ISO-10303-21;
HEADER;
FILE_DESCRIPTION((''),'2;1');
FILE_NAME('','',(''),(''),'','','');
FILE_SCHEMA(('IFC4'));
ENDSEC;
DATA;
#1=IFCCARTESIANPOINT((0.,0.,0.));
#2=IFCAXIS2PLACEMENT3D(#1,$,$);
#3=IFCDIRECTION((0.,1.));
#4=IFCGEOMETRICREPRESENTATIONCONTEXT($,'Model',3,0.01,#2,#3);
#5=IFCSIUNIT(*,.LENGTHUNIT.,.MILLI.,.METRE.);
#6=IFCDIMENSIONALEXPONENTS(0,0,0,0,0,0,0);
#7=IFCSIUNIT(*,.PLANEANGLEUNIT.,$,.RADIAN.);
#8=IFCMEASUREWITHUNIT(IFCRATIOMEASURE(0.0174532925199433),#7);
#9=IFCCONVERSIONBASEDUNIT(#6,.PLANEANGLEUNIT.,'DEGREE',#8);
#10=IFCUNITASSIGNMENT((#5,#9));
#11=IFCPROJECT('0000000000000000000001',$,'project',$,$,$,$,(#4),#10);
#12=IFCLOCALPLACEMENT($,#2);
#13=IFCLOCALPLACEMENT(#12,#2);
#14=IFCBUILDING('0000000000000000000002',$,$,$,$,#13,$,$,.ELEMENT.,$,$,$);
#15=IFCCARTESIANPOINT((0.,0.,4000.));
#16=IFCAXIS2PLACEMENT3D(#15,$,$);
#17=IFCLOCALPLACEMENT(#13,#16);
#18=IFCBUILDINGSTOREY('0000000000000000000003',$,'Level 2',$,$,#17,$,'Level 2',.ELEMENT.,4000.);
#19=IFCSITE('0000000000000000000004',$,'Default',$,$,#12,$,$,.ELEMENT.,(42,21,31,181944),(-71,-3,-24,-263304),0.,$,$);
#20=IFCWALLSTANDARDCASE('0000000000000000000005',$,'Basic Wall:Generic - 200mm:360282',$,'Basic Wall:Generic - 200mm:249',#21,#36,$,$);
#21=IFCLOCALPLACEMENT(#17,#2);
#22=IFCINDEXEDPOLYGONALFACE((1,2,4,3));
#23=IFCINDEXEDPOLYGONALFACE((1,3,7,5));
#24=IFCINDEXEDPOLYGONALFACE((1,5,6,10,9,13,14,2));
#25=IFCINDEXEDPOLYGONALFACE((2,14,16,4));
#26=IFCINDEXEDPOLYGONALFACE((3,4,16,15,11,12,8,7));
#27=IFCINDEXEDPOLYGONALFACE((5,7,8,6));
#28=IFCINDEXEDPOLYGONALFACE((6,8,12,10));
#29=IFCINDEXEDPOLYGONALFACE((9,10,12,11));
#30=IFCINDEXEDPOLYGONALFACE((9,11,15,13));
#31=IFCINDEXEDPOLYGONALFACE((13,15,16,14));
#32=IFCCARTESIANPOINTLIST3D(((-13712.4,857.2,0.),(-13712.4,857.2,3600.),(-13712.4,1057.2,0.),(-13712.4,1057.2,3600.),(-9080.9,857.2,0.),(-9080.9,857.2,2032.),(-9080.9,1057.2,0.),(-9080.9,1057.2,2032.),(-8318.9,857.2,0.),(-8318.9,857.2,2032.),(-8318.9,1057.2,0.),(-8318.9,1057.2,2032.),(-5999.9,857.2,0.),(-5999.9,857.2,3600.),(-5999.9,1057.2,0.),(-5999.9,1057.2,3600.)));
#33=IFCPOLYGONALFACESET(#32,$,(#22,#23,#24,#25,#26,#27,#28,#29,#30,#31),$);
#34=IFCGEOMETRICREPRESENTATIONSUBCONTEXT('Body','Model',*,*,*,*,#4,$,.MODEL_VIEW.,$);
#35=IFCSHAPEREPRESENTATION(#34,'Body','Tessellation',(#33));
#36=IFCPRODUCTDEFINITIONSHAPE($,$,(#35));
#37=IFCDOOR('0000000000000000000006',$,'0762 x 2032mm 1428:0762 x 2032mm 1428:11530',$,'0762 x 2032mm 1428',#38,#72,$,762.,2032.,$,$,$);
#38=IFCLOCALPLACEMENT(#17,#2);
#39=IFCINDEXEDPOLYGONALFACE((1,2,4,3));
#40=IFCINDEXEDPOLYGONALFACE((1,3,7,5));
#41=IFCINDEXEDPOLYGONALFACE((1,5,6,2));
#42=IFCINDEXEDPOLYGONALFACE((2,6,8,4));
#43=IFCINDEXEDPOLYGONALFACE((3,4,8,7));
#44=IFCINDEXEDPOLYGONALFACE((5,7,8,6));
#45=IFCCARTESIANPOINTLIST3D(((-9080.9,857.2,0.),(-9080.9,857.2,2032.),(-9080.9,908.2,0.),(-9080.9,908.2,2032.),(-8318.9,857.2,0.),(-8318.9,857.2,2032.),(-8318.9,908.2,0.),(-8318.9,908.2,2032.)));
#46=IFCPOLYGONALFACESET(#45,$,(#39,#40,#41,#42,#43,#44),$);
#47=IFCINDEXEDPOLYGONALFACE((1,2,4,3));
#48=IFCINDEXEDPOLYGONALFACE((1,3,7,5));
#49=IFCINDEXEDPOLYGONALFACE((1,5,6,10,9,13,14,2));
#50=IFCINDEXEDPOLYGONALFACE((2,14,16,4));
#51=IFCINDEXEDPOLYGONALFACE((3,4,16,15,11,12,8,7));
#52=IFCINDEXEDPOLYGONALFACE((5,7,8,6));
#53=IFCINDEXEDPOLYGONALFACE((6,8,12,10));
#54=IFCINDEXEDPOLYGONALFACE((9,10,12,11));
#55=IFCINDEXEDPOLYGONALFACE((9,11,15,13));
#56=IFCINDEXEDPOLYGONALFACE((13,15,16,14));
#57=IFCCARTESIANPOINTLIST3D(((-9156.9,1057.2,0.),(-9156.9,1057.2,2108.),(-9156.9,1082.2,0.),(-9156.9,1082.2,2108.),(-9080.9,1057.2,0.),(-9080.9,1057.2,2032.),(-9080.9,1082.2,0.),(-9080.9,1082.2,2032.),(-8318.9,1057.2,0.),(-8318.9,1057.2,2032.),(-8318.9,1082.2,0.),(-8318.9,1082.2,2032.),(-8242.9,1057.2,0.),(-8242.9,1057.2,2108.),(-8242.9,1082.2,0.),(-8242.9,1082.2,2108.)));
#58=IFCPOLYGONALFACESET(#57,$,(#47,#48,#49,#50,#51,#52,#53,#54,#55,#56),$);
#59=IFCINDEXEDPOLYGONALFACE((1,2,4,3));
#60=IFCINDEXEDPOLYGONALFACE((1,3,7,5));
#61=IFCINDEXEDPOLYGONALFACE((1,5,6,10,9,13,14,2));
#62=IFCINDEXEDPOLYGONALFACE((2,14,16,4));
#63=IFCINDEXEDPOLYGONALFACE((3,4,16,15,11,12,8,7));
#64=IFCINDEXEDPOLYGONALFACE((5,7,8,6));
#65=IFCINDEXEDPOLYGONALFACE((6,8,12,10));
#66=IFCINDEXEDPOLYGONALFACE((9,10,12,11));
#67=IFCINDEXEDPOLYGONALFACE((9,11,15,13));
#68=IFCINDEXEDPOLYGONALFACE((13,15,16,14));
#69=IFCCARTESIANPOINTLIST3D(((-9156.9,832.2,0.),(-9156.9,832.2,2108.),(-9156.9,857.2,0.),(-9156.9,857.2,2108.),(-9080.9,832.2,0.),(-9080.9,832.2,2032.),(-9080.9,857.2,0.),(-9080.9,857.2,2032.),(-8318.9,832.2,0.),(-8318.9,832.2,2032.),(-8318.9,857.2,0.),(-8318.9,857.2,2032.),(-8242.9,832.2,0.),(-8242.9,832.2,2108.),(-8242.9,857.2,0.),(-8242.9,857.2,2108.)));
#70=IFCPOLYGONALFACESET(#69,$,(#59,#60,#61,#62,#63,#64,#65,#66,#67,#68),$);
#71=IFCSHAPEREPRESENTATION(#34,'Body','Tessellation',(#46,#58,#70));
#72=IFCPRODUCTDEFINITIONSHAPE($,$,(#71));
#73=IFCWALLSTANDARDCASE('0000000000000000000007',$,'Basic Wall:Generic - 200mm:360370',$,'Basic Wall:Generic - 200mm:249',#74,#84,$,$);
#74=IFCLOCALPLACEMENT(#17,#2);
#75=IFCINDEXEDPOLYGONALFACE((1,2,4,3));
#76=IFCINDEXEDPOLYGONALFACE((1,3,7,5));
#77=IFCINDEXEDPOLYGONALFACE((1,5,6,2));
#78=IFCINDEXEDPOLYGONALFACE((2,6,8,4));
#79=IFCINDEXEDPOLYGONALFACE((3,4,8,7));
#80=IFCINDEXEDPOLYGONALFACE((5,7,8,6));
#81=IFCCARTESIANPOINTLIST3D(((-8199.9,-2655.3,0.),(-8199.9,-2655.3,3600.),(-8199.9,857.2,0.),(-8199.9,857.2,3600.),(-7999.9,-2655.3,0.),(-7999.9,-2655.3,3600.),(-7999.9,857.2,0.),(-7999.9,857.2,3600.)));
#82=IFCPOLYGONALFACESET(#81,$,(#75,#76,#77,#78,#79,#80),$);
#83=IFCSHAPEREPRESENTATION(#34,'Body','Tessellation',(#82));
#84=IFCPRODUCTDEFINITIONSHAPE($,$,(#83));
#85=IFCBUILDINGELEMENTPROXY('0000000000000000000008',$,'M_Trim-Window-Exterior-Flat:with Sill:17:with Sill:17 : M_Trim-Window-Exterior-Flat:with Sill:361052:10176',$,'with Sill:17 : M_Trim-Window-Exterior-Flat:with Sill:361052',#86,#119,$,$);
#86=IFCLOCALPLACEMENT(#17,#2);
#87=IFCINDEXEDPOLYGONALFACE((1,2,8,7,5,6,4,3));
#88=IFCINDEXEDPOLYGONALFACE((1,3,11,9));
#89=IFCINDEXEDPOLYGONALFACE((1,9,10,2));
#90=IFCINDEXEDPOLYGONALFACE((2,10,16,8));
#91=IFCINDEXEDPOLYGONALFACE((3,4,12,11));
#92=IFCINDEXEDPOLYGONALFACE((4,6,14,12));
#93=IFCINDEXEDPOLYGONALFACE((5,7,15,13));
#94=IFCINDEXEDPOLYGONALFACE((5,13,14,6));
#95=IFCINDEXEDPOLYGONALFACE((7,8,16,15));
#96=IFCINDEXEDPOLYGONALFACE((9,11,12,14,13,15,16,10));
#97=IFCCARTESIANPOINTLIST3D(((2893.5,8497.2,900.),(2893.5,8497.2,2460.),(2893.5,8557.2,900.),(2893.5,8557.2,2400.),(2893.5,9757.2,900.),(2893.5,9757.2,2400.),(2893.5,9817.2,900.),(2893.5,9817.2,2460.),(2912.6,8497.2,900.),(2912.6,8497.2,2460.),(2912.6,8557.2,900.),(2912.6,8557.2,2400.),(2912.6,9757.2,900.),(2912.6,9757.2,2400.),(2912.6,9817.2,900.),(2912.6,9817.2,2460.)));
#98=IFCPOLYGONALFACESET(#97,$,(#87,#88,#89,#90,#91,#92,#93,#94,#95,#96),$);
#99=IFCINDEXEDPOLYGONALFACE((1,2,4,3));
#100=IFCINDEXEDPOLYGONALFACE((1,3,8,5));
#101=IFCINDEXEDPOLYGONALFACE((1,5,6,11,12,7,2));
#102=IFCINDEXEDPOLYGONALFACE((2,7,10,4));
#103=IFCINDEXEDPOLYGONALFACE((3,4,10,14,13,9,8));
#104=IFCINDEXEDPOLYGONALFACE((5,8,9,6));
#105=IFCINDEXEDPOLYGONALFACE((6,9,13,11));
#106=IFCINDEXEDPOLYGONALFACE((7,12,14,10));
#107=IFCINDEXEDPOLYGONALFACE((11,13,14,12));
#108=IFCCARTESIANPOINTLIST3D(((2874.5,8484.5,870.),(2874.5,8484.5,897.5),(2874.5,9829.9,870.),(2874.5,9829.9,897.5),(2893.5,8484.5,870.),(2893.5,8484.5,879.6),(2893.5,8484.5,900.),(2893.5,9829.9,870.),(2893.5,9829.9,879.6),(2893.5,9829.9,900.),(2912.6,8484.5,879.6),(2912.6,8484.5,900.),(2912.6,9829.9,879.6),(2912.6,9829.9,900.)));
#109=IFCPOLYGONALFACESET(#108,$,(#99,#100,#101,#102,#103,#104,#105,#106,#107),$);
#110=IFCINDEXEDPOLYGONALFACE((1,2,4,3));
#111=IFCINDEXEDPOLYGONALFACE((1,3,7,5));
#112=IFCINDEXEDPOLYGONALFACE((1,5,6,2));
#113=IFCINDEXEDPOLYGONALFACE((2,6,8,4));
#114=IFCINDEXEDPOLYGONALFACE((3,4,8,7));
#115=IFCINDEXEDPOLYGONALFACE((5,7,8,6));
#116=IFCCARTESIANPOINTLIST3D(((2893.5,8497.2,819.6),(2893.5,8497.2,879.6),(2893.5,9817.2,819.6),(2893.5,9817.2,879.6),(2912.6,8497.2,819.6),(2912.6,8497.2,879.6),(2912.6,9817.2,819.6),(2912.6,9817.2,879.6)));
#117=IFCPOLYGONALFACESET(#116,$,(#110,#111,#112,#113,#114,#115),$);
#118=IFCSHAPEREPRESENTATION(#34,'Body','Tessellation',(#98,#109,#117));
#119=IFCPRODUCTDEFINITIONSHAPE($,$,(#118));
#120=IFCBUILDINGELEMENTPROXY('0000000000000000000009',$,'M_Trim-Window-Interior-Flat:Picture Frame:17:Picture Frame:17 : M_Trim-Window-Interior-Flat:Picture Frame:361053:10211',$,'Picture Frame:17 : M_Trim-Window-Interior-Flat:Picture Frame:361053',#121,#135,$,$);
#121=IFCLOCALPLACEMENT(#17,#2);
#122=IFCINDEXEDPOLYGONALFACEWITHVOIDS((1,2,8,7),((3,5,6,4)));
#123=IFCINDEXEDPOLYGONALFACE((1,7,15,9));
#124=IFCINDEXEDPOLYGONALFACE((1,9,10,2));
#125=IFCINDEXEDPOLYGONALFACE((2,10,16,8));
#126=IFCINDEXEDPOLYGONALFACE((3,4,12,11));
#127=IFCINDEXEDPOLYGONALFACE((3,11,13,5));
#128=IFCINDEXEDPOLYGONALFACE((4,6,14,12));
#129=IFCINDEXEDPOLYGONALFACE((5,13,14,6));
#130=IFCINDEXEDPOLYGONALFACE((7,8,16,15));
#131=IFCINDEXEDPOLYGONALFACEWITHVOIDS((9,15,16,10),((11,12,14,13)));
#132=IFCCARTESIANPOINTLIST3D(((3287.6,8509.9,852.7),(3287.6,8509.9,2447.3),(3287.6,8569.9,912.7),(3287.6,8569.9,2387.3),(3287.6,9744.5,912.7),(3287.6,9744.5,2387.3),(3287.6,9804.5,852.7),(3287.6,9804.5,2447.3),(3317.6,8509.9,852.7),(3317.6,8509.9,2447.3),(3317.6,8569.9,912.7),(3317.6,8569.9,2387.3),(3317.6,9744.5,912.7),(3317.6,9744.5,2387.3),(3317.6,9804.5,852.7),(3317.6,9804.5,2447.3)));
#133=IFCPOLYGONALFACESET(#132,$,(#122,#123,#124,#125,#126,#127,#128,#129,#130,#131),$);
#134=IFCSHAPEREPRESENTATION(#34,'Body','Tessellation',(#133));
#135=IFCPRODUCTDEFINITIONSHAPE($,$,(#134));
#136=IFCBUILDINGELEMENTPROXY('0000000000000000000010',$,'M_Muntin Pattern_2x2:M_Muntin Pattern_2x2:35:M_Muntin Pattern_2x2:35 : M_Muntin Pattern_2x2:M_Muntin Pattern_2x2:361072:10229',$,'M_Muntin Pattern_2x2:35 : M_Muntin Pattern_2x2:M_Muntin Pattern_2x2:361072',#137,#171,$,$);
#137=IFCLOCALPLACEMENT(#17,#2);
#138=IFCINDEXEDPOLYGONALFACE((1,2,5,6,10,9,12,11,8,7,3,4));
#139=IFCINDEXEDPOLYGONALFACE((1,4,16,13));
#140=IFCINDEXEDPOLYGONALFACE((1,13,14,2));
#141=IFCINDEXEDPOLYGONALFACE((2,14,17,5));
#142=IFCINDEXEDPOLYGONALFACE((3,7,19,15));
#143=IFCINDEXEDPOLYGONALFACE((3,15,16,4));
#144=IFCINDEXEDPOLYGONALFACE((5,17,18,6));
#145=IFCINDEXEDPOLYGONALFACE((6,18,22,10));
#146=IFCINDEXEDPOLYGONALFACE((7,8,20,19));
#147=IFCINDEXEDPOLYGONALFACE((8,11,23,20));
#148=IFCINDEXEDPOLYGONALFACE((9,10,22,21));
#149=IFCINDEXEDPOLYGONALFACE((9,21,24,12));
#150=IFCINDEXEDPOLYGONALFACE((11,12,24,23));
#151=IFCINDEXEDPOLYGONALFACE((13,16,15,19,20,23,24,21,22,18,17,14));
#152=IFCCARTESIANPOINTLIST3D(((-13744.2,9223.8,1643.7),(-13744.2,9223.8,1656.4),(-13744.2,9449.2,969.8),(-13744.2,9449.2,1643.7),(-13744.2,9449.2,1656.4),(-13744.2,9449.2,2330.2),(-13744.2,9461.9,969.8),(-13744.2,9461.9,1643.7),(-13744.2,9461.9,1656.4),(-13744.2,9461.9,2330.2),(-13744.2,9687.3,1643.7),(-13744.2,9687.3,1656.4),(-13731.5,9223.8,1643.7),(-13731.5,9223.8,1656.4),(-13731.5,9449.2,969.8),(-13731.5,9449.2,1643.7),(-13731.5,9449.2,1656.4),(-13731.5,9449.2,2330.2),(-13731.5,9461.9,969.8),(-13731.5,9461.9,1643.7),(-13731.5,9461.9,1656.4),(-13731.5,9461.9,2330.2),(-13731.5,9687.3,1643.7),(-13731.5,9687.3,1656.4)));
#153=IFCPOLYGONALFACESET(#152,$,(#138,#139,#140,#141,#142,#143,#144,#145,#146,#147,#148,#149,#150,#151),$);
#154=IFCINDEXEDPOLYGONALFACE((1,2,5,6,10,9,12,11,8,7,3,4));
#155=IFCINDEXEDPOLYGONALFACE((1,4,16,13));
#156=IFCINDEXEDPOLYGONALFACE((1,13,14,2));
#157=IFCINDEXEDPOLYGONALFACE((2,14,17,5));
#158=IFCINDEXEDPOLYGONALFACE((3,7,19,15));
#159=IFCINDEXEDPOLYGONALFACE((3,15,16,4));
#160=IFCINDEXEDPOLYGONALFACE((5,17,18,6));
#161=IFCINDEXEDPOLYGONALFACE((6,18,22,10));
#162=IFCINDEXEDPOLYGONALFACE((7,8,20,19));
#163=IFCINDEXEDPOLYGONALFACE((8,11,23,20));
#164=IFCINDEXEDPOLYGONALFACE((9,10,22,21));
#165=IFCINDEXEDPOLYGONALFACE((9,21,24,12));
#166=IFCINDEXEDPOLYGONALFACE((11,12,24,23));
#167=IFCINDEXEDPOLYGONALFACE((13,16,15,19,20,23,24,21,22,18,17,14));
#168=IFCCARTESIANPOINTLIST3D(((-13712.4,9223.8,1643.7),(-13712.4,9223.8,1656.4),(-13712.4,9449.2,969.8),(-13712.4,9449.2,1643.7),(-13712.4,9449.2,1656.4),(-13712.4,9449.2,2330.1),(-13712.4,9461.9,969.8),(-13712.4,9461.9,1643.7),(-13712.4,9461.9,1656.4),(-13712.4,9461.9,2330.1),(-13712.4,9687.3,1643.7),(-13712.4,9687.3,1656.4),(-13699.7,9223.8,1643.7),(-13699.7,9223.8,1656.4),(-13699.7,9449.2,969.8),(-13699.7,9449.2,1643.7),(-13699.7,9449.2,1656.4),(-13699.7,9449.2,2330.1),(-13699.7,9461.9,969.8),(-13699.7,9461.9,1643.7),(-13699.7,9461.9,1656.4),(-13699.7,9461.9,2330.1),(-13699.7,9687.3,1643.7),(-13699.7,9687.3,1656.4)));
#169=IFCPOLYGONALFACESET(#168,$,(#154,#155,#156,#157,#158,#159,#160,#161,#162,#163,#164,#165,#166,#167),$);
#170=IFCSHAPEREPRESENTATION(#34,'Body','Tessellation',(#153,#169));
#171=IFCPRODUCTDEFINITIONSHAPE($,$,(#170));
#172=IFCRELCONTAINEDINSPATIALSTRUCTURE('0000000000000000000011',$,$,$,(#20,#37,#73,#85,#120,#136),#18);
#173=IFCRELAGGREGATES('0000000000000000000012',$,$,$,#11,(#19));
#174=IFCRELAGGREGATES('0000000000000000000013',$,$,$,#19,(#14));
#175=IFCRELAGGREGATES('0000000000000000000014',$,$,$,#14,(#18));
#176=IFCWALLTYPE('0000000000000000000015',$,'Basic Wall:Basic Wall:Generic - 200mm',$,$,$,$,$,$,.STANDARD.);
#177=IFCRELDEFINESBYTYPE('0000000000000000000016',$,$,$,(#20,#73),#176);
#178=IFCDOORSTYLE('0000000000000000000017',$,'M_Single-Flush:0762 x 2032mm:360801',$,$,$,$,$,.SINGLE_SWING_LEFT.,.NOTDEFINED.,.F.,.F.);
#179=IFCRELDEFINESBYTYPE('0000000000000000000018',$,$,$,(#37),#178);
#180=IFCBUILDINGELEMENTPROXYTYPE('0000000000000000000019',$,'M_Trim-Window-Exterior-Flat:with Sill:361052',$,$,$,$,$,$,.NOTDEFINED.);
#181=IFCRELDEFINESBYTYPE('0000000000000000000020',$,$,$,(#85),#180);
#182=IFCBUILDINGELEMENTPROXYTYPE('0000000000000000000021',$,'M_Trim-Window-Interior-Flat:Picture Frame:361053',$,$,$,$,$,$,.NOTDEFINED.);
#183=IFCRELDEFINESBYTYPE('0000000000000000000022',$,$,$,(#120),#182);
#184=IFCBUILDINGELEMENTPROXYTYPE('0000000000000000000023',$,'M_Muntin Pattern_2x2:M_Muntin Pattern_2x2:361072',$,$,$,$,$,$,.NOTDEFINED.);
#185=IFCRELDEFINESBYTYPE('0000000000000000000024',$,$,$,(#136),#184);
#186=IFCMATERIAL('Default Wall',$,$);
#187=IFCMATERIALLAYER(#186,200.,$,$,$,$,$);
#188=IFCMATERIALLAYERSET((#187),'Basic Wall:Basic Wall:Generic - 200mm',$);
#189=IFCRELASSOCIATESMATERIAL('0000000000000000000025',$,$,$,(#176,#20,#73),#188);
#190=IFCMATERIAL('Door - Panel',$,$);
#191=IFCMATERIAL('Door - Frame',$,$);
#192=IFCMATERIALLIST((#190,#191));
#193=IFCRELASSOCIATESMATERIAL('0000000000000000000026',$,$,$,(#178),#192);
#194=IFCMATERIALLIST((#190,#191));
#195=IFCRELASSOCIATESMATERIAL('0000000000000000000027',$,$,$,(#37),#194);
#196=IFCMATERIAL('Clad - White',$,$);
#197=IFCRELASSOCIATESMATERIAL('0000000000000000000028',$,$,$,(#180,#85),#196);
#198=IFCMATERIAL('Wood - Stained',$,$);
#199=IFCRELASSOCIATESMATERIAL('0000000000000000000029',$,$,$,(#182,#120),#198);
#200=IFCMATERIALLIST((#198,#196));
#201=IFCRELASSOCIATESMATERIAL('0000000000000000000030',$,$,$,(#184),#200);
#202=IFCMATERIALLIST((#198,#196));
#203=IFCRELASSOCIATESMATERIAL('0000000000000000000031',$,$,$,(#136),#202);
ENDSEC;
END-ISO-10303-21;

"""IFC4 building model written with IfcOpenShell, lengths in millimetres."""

from ifc_helpers import new_model, entity, si_unit, converted_unit, direction, frame, frame_2d, origin, origin_2d_with_axis, place, context, subcontext, project, spatial, polyline, rectangle, outline, extrude, source, transform, mapped, material, material_list, layer, layer_set, layer_usage, type_object, type_shapes, element, fill, save


model = new_model("IFC4")

# Units and contexts
model_context = context("Model", 3, precision=0.01, world=origin(), true_north=direction((0.0, 1.0)))
body_context = subcontext(model_context, "Body", "Model", "MODEL_VIEW")
ifc_project = project(units=[si_unit("LENGTHUNIT", "METRE", prefix="MILLI"), converted_unit("PLANEANGLEUNIT", "DEGREE", entity("IfcRatioMeasure", 0.0174532925199433), si_unit("PLANEANGLEUNIT", "RADIAN"), dimensions=[0, 0, 0, 0, 0, 0, 0])], contexts=[model_context])

# Site, building, storey
site_placement = place(None, origin())
site = spatial("IfcSite", under=ifc_project, at=site_placement, Name="Default", CompositionType="ELEMENT", RefLatitude=(42, 21, 31, 181944), RefLongitude=(-71, -3, -24, -263304), RefElevation=0.0)
building_placement = place(site_placement, origin())
building = spatial("IfcBuilding", under=site, at=building_placement, CompositionType="ELEMENT")
storey_placement = place(building_placement, frame((0.0, 0.0, 4000.0)))
storey = spatial("IfcBuildingStorey", under=building, at=storey_placement, Name="Level 2", LongName="Level 2", CompositionType="ELEMENT", Elevation=4000.0)

# Shared definitions
ifc_material_1 = material(Name="Default Wall")
ifc_material_2 = material(Name="Door - Panel")
ifc_material_3 = material(Name="Door - Frame")

# Shared definitions
ifc_layer_1 = layer(ifc_material_1, 200.0)
ifc_layer_set_1 = layer_set([ifc_layer_1], Name="Basic Wall:Basic Wall:Generic - 200mm")
wall_type_1 = type_object("IfcWallType", Name="Basic Wall:Basic Wall:Generic - 200mm", PredefinedType="STANDARD", material=ifc_layer_set_1)
ifc_material_list_1 = material_list([ifc_material_2, ifc_material_3])
door_style_1 = type_object("IfcDoorStyle", Name="M_Single-Flush:0762 x 2032mm:360801", ConstructionType="NOTDEFINED", OperationType="SINGLE_SWING_LEFT", ParameterTakesPrecedence=False, Sizeable=False, material=ifc_material_list_1)
shared_shape_1 = source(origin(), body_context, "Body", "SweptSolid", [
    extrude(rectangle(XDim=51.0, YDim=762.0, at=origin_2d_with_axis()), frame((381.0, -27.5, 0.0), z_axis=(0.0, 0.0, 1.0), x_axis=(0.0, 1.0, 0.0)), (0.0, 0.0, 1.0), 2032.0),
    extrude(outline(polyline([(-1035.0, -457.0), (1073.0, -457.0), (1073.0, 457.0), (-1035.0, 457.0), (-1035.0, 381.0), (997.0, 381.0), (997.0, -381.0), (-1035.0, -381.0), (-1035.0, -457.0)])), frame((381.0, -227.0, 1035.0), z_axis=(0.0, 1.0, 0.0), x_axis=(0.0, 0.0, 1.0)), (0.0, 0.0, 1.0), 25.0),
    extrude(outline(polyline([(-457.0, -1073.0), (457.0, -1073.0), (457.0, 1035.0), (381.0, 1035.0), (381.0, -997.0), (-381.0, -997.0), (-381.0, 1035.0), (-457.0, 1035.0), (-457.0, -1073.0)])), frame((381.0, -2.0, 1035.0), z_axis=(0.0, 1.0, 0.0), x_axis=(1.0, 0.0, 0.0)), (0.0, 0.0, 1.0), 25.0),
])
type_shapes(door_style_1, [shared_shape_1])

# Wall, opening, door
ifc_layer_usage_1 = layer_usage(ifc_layer_set_1, "AXIS2", "NEGATIVE", 100.0)
wall_1_placement = place(storey_placement, frame((-5999.9, 957.2, 0.0), z_axis=(0.0, 0.0, 1.0), x_axis=(-1.0, 0.0, 0.0)))
wall_1 = element("IfcWallStandardCase", 1, at=wall_1_placement, inside=storey, type_object=wall_type_1, material=ifc_layer_usage_1, Name="Basic Wall:Generic - 200mm:360282", ObjectType="Basic Wall:Generic - 200mm:249", context=body_context, shape_type="SweptSolid", body=[
    extrude(rectangle(XDim=7712.5, YDim=200.0, at=frame_2d((3856.2, 0.0), x_axis=(-1.0, 0.0))), origin(), (0.0, 0.0, 1.0), 3600.0),
])
opening_1_placement = place(wall_1_placement, frame((-5999.9, 957.2, 0.0), z_axis=(0.0, 0.0, 1.0), x_axis=(-1.0, 0.0, 0.0)))
opening_1 = element("IfcOpeningElement", 2, at=opening_1_placement, cuts=wall_1, ObjectType="Opening", context=body_context, shape_type="SweptSolid", body=[
    extrude(rectangle(XDim=2032.0, YDim=762.0, at=frame_2d((0.0, 0.0), x_axis=(1.0, 0.0))), frame((-8699.9, 1059.2, 1016.0), z_axis=(0.0, -1.0, 0.0), x_axis=(0.0, 0.0, 1.0)), (0.0, 0.0, 1.0), 204.0),
])
ifc_material_list_2 = material_list([ifc_material_2, ifc_material_3])
door_1_placement = place(opening_1_placement, frame((-8318.9, 855.2, 0.0), z_axis=(0.0, 0.0, 1.0), x_axis=(-1.0, 0.0, 0.0)))
door_1 = element("IfcDoor", 3, at=door_1_placement, inside=storey, type_object=door_style_1, material=ifc_material_list_2, Name="0762 x 2032mm 1428:0762 x 2032mm 1428:11530", ObjectType="0762 x 2032mm 1428", OverallHeight=762.0, OverallWidth=2032.0, context=body_context, shape_type="MappedRepresentation", body=[
    mapped(shared_shape_1, transform((0.0, 0.0, 0.0), scale=1.0)),
])
fill(opening_1, door_1)

# Wall
ifc_layer_usage_2 = layer_usage(ifc_layer_set_1, "AXIS2", "NEGATIVE", 100.0)
wall_2_placement = place(storey_placement, frame((-8099.9, 857.2, 0.0), z_axis=(0.0, 0.0, 1.0), x_axis=(0.0, -1.0, 0.0)))
element("IfcWallStandardCase", 4, at=wall_2_placement, inside=storey, type_object=wall_type_1, material=ifc_layer_usage_2, Name="Basic Wall:Generic - 200mm:360370", ObjectType="Basic Wall:Generic - 200mm:249", context=body_context, shape_type="SweptSolid", body=[
    extrude(rectangle(XDim=3512.5, YDim=200.0, at=frame_2d((1756.2, 0.0), x_axis=(-1.0, 0.0))), origin(), (0.0, 0.0, 1.0), 3600.0),
])

# Building element proxies
ifc_material_4 = material(Name="Clad - White")
building_element_proxy_type_1 = type_object("IfcBuildingElementProxyType", Name="M_Trim-Window-Exterior-Flat:with Sill:361052", PredefinedType="NOTDEFINED", material=ifc_material_4)
shared_shape_2 = source(origin(), body_context, "Body", "SweptSolid", [
    extrude(outline(polyline([(-765.0, -660.0), (795.0, -660.0), (795.0, 660.0), (-765.0, 660.0), (-765.0, 600.0), (735.0, 600.0), (735.0, -600.0), (-765.0, -600.0), (-765.0, -660.0)])), frame((2893.5, 9157.2, 5665.0), z_axis=(1.0, 0.0, 0.0), x_axis=(0.0, 0.0, 1.0)), (0.0, 0.0, 1.0), 19.1),
    extrude(outline(polyline([(0.0, -15.2), (19.0, -15.2), (19.0, 12.3), (0.0, 14.8), (-19.0, 14.8), (-19.0, -5.7), (0.0, -5.7), (0.0, -15.2)])), frame((2893.5, 8484.5, 4885.2), z_axis=(0.0, 1.0, 0.0), x_axis=(-1.0, 0.0, 0.0)), (0.0, 0.0, 1.0), 1345.4),
    extrude(rectangle(XDim=19.1, YDim=1320.0, at=frame_2d((0.0, 0.0), x_axis=(1.0, 0.0))), frame((2903.0, 9157.2, 4819.6)), (0.0, 0.0, 1.0), 60.0),
])
type_shapes(building_element_proxy_type_1, [shared_shape_2])
proxy_1_placement = place(storey_placement, frame((0.0, 0.0, -4000.0)))
element("IfcBuildingElementProxy", 5, at=proxy_1_placement, inside=storey, type_object=building_element_proxy_type_1, material=ifc_material_4, Name="M_Trim-Window-Exterior-Flat:with Sill:17:with Sill:17 : M_Trim-Window-Exterior-Flat:with Sill:361052:10176", ObjectType="with Sill:17 : M_Trim-Window-Exterior-Flat:with Sill:361052", context=body_context, shape_type="MappedRepresentation", body=[
    mapped(shared_shape_2, transform((0.0, 0.0, 0.0), scale=1.0)),
])
ifc_material_5 = material(Name="Wood - Stained")
building_element_proxy_type_2 = type_object("IfcBuildingElementProxyType", Name="M_Trim-Window-Interior-Flat:Picture Frame:361053", PredefinedType="NOTDEFINED", material=ifc_material_5)
shared_shape_3 = source(origin(), body_context, "Body", "SweptSolid", [
    extrude(outline(polyline([(-797.3, -647.3), (797.3, -647.3), (797.3, 647.3), (-797.3, 647.3), (-797.3, -647.3)]), holes=[polyline([(737.3, 587.3), (737.3, -587.3), (-737.3, -587.3), (-737.3, 587.3), (737.3, 587.3)])]), frame((3287.6, 9157.2, 5650.0), z_axis=(1.0, 0.0, 0.0), x_axis=(0.0, 0.0, -1.0)), (0.0, 0.0, 1.0), 30.0),
])
type_shapes(building_element_proxy_type_2, [shared_shape_3])
proxy_2_placement = place(storey_placement, frame((0.0, 0.0, -4000.0)))
element("IfcBuildingElementProxy", 6, at=proxy_2_placement, inside=storey, type_object=building_element_proxy_type_2, material=ifc_material_5, Name="M_Trim-Window-Interior-Flat:Picture Frame:17:Picture Frame:17 : M_Trim-Window-Interior-Flat:Picture Frame:361053:10211", ObjectType="Picture Frame:17 : M_Trim-Window-Interior-Flat:Picture Frame:361053", context=body_context, shape_type="MappedRepresentation", body=[
    mapped(shared_shape_3, transform((0.0, 0.0, 0.0), scale=1.0)),
])
ifc_material_list_3 = material_list([ifc_material_5, ifc_material_4])
ifc_material_list_4 = material_list([ifc_material_5, ifc_material_4])
building_element_proxy_type_3 = type_object("IfcBuildingElementProxyType", Name="M_Muntin Pattern_2x2:M_Muntin Pattern_2x2:361072", PredefinedType="NOTDEFINED", material=ifc_material_list_4)
shared_shape_4 = source(origin(), body_context, "Body", "SweptSolid", [
    extrude(outline(polyline([(-6.4, -680.2), (6.3, -680.2), (6.3, -6.4), (231.7, -6.4), (231.7, 6.3), (6.3, 6.3), (6.3, 680.2), (-6.4, 680.2), (-6.4, 6.3), (-231.7, 6.3), (-231.7, -6.4), (-6.4, -6.4), (-6.4, -680.2)])), frame((-13744.2, 9455.6, 5650.0), z_axis=(1.0, 0.0, 0.0), x_axis=(0.0, -1.0, 0.0)), (0.0, 0.0, 1.0), 12.7),
    extrude(outline(polyline([(-6.4, -680.1), (6.3, -680.1), (6.3, -6.4), (231.7, -6.4), (231.7, 6.3), (6.3, 6.3), (6.3, 680.2), (-6.4, 680.2), (-6.4, 6.3), (-231.7, 6.3), (-231.7, -6.4), (-6.4, -6.4), (-6.4, -680.1)])), frame((-13712.4, 9455.6, 5650.0), z_axis=(1.0, 0.0, 0.0), x_axis=(0.0, -1.0, 0.0)), (0.0, 0.0, 1.0), 12.7),
])
type_shapes(building_element_proxy_type_3, [shared_shape_4])
proxy_3_placement = place(storey_placement, frame((0.0, 0.0, -4000.0)))
element("IfcBuildingElementProxy", 7, at=proxy_3_placement, inside=storey, type_object=building_element_proxy_type_3, material=ifc_material_list_3, Name="M_Muntin Pattern_2x2:M_Muntin Pattern_2x2:35:M_Muntin Pattern_2x2:35 : M_Muntin Pattern_2x2:M_Muntin Pattern_2x2:361072:10229", ObjectType="M_Muntin Pattern_2x2:35 : M_Muntin Pattern_2x2:M_Muntin Pattern_2x2:361072", context=body_context, shape_type="MappedRepresentation", body=[
    mapped(shared_shape_4, transform((0.0, 0.0, 0.0), scale=1.0)),
])

save(model, "model.ifc")
